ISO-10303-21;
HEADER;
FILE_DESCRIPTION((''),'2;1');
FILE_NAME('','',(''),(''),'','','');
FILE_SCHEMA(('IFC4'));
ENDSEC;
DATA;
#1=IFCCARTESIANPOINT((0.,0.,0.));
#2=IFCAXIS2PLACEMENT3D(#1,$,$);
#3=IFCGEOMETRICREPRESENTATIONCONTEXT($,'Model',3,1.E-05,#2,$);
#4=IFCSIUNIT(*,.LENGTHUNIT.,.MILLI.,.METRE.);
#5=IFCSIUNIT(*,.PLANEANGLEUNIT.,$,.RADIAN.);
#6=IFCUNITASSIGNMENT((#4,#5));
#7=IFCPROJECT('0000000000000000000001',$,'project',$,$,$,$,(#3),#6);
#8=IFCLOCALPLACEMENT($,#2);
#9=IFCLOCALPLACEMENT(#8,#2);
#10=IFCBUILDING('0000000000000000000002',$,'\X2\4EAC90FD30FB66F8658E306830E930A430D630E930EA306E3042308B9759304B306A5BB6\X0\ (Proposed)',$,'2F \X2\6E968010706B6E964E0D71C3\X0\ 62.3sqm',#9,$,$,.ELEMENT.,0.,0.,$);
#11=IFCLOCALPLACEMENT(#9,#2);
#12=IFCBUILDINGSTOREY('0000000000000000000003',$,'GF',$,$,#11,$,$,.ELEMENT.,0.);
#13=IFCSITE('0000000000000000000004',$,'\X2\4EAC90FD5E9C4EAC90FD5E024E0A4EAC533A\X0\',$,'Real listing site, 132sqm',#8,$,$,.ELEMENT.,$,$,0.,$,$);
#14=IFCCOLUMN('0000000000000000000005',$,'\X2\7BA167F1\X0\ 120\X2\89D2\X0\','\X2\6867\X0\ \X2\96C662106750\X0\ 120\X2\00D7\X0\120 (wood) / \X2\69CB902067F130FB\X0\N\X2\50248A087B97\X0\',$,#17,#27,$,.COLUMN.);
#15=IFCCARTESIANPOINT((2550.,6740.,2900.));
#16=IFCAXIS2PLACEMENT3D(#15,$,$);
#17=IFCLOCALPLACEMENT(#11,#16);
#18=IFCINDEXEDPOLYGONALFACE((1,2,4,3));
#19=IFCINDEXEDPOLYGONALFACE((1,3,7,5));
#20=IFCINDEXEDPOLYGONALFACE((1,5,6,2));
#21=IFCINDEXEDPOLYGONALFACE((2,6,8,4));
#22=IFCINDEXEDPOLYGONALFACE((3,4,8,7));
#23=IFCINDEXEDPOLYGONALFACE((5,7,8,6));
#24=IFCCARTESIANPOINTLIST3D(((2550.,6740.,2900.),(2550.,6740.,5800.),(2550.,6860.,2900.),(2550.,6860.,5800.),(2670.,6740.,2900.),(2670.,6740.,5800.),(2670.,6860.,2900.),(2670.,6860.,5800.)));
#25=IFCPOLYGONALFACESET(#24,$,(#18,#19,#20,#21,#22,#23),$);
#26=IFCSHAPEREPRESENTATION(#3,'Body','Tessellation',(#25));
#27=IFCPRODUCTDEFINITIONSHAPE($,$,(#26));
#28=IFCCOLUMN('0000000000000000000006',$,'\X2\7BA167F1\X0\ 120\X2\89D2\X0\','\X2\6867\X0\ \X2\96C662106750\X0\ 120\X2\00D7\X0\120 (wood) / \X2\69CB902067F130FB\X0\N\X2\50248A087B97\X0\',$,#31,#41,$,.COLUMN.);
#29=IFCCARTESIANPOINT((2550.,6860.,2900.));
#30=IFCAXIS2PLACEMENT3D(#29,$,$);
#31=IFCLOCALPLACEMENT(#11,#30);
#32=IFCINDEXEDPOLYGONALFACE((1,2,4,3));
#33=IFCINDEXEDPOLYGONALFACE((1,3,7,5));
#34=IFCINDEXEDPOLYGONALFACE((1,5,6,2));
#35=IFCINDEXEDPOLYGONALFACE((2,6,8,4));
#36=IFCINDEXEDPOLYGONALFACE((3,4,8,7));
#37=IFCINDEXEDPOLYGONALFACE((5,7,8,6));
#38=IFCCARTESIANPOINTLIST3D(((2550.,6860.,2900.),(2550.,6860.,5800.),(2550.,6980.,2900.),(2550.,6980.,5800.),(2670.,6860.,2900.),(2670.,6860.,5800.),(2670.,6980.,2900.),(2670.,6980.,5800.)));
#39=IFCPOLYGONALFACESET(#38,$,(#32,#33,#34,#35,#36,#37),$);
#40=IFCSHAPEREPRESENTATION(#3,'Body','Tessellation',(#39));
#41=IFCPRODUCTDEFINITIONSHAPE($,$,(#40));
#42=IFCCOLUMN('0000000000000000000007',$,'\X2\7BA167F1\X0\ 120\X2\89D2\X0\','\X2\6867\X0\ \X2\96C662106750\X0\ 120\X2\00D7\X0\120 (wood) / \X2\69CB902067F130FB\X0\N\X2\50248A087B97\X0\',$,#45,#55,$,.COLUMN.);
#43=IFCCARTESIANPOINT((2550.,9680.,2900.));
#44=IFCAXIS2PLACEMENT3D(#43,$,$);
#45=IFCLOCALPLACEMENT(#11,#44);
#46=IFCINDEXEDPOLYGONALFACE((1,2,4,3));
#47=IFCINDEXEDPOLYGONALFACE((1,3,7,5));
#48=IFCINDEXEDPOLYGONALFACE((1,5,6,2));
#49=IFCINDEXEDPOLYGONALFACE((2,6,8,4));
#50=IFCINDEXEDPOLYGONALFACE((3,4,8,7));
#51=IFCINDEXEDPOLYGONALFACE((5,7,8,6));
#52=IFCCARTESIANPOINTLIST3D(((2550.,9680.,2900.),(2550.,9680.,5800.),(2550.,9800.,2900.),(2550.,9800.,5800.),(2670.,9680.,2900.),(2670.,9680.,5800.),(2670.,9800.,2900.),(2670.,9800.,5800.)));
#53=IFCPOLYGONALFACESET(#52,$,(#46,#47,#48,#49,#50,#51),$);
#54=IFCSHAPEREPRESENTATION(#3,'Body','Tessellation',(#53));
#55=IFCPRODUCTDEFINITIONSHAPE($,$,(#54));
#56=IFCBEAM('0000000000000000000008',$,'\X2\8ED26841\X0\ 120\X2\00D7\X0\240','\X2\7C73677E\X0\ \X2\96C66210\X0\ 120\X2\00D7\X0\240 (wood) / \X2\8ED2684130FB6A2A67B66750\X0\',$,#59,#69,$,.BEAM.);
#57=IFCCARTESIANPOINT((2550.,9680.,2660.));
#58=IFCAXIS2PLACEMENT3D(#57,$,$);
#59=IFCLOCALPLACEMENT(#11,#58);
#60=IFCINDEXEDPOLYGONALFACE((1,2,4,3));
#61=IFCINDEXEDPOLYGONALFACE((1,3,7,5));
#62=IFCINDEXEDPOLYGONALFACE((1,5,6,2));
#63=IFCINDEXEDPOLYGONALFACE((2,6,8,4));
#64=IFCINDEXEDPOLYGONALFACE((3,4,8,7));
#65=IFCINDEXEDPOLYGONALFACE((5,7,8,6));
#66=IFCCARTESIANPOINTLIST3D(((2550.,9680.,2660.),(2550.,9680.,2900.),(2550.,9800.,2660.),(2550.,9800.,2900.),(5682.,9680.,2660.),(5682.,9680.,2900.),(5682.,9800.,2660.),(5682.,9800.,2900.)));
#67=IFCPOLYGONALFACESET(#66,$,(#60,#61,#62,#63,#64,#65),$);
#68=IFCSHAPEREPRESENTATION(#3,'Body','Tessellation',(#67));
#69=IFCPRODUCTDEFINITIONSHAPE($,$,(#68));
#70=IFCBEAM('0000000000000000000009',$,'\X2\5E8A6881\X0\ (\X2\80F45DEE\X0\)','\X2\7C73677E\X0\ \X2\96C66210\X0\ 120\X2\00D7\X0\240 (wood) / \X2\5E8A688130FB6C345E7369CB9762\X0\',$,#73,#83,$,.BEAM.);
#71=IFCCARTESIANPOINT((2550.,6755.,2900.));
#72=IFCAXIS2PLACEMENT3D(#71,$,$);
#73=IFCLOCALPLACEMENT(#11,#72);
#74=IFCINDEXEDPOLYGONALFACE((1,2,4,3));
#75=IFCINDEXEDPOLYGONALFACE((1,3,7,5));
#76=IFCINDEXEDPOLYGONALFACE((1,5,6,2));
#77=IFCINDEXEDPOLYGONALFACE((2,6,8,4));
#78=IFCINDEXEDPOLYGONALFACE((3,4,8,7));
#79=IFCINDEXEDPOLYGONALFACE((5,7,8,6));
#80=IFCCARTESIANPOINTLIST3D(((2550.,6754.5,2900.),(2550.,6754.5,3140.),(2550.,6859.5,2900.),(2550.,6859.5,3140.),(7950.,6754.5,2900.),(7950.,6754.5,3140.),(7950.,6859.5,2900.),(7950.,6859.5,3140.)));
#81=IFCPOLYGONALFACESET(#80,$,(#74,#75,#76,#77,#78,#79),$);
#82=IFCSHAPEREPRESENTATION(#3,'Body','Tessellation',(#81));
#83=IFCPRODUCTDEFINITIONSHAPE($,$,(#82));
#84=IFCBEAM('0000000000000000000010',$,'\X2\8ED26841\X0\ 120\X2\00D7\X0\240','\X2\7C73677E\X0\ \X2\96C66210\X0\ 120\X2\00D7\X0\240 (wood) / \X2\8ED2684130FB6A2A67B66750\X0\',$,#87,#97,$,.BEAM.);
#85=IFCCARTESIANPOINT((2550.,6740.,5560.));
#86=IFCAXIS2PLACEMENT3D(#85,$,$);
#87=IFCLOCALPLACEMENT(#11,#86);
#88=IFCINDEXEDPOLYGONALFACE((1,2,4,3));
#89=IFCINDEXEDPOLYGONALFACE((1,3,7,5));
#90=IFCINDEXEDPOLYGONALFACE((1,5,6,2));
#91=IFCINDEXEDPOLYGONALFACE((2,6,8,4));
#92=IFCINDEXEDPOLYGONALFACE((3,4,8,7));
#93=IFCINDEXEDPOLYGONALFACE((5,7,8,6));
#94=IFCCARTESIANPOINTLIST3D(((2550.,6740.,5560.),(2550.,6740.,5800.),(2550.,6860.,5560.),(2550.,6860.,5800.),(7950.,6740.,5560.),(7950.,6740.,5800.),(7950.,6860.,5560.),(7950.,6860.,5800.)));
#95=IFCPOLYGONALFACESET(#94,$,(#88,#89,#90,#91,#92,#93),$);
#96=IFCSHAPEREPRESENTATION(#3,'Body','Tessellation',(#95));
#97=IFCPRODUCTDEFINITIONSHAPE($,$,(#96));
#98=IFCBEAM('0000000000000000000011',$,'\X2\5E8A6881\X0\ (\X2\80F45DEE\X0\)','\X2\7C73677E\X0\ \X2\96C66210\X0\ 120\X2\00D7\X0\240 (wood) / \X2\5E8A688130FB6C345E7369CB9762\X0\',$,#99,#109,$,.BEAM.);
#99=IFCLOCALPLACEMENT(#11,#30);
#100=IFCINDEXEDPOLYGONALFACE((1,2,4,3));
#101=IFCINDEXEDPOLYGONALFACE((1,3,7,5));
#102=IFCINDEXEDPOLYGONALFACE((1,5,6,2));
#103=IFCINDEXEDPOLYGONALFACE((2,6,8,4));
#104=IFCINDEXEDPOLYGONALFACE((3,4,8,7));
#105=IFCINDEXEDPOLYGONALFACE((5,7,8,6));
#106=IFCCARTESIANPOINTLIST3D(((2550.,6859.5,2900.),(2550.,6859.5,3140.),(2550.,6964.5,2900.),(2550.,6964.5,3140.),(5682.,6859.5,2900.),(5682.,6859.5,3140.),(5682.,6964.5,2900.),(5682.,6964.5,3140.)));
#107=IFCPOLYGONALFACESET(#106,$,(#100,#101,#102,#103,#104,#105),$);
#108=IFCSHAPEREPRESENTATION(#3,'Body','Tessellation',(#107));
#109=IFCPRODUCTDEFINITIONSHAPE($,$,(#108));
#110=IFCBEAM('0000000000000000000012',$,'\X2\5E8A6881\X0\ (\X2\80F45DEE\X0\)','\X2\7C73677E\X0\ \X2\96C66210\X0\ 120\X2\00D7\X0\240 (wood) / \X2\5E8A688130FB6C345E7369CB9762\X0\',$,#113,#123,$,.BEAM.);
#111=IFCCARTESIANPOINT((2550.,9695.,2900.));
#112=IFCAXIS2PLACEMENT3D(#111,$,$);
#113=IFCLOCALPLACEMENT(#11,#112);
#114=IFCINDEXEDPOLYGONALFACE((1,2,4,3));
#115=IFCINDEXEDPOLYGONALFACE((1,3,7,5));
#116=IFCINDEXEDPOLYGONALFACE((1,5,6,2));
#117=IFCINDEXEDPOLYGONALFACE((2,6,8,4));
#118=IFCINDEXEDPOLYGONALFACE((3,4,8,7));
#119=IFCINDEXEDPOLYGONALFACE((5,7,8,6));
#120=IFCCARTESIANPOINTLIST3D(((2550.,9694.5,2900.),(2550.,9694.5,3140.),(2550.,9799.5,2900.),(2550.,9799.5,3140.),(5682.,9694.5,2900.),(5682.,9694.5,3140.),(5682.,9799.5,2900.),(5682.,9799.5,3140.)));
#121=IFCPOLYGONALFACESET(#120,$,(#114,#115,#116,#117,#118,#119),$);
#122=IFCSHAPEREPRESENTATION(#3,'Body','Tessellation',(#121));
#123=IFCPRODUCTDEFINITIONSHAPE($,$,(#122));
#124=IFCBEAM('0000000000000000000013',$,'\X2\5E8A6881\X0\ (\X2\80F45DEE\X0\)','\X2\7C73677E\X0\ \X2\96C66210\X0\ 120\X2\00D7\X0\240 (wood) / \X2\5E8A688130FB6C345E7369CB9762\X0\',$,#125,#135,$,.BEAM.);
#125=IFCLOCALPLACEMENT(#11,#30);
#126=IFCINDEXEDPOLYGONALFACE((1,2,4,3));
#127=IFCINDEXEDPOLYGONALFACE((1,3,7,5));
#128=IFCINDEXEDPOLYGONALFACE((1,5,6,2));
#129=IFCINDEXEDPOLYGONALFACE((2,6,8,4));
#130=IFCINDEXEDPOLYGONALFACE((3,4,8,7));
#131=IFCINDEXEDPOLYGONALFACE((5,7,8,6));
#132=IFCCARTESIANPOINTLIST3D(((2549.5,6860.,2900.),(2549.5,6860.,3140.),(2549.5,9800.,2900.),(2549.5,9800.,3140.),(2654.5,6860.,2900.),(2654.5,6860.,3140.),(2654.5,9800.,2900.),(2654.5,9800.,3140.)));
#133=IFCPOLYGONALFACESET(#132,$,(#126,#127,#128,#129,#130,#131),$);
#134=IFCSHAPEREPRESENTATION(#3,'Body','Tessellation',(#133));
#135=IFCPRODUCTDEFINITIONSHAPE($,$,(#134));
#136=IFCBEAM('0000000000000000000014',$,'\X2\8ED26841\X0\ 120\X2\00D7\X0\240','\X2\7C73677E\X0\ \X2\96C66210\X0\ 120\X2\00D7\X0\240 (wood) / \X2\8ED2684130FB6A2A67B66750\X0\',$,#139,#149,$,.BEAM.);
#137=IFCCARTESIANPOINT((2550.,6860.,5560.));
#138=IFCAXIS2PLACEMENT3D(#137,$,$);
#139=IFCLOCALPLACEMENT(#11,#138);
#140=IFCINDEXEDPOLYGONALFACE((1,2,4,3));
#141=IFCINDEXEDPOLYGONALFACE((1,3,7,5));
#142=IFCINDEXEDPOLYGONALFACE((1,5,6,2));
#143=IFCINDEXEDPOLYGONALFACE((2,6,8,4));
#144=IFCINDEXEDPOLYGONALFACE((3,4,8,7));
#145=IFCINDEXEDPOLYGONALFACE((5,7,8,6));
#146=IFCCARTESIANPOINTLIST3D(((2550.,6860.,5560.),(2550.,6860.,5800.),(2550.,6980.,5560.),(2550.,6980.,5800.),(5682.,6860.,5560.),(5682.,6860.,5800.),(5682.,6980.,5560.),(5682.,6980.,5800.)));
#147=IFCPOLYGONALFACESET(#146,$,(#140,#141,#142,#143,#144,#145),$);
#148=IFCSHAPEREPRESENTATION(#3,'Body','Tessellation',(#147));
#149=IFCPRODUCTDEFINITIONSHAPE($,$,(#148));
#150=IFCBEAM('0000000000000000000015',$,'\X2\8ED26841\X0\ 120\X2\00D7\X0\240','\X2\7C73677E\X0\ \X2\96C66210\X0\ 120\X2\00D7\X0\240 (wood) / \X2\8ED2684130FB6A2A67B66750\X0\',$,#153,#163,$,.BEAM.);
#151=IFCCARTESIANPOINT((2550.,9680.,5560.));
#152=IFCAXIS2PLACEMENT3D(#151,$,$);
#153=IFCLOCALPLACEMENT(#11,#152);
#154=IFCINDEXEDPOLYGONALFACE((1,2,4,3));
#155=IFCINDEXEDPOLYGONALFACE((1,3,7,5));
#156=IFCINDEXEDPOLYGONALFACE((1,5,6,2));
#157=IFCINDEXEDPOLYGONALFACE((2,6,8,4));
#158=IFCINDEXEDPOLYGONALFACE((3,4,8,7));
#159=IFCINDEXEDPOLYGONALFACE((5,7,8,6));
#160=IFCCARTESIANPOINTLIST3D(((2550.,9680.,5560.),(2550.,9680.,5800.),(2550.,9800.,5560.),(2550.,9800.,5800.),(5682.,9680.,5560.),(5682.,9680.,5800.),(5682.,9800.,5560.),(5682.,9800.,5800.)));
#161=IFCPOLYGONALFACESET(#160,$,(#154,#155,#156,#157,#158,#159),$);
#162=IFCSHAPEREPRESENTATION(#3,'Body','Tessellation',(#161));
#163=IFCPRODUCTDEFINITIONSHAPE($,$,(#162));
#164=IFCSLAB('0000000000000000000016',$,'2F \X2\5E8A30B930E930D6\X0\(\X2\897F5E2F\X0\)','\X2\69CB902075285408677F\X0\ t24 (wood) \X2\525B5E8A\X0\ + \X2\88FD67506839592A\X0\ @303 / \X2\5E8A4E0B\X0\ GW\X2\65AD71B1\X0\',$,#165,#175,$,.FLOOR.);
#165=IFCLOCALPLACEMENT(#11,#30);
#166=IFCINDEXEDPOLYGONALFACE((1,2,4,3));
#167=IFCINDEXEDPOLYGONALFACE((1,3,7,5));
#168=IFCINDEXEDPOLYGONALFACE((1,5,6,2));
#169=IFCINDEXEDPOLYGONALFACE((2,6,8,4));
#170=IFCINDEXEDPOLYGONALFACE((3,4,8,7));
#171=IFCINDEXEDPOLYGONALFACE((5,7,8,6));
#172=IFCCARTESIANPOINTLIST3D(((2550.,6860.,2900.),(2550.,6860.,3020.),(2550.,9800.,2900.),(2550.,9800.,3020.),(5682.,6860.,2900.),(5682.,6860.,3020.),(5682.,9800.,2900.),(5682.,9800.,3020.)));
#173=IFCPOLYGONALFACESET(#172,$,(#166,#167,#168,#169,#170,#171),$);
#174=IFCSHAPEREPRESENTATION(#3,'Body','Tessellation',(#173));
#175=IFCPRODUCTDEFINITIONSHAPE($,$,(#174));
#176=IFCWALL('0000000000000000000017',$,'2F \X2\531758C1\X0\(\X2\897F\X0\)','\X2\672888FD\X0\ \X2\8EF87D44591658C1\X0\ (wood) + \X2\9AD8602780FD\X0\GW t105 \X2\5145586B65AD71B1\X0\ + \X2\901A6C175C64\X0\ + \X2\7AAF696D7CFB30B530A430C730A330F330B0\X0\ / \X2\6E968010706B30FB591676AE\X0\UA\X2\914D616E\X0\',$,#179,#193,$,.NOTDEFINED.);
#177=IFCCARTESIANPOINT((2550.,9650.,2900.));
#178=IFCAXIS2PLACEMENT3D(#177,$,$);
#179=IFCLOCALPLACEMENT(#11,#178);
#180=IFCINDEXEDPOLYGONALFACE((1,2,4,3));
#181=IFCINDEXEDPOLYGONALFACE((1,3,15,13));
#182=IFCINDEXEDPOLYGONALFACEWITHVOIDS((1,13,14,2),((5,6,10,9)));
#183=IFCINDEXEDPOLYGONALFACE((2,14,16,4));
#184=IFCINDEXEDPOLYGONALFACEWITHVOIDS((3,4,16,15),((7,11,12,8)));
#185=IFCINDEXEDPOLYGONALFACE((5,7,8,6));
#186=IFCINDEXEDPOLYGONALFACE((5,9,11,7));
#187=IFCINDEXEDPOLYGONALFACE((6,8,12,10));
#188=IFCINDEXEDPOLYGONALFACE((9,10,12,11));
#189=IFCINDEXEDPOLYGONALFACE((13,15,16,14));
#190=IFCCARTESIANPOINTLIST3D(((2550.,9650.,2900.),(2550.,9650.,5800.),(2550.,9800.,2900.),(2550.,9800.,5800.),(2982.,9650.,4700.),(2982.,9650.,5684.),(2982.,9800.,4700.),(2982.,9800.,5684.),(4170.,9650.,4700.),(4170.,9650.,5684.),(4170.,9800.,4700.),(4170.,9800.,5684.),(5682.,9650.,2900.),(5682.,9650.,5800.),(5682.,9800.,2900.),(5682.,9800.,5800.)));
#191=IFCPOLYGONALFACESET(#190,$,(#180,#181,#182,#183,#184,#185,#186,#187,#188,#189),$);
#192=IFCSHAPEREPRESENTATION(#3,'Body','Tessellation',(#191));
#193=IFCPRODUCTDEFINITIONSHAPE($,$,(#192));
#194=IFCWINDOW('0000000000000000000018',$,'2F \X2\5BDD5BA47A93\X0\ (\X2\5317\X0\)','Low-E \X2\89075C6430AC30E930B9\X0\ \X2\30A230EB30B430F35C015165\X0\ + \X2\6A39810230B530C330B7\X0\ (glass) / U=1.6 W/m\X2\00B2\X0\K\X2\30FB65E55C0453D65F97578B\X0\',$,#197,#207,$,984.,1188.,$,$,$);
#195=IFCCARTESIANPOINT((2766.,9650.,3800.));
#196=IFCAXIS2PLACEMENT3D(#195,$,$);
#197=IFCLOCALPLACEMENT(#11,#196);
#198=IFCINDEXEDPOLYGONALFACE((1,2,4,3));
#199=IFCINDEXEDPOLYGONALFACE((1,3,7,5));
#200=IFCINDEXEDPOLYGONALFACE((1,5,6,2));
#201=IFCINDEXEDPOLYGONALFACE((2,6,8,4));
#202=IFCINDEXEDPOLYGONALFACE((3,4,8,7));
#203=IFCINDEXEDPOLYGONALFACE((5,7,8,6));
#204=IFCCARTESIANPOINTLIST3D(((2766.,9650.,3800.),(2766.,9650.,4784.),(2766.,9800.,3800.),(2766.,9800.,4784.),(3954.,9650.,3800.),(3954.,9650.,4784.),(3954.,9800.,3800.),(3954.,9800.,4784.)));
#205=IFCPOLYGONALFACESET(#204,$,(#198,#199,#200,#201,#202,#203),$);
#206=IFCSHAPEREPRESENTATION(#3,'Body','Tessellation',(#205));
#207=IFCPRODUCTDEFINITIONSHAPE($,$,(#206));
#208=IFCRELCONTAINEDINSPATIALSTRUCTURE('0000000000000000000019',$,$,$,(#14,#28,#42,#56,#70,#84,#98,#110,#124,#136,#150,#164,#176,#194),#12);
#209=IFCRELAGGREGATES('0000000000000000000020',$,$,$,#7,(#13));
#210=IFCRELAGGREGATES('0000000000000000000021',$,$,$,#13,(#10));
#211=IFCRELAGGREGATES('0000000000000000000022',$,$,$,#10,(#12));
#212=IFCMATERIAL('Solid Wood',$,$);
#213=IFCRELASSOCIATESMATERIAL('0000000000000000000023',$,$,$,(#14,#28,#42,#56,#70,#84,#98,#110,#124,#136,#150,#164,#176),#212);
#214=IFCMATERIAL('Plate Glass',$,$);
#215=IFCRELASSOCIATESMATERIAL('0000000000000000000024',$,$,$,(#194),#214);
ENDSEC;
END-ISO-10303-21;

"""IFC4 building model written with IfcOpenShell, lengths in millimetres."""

from ifc_helpers import new_model, si_unit, frame, frame_2d, origin, place, context, project, spatial, rectangle, extrude, material, element, fill, save


model = new_model("IFC4")

# Units and contexts
model_context = context("Model", 3, precision=1e-05, world=origin())
ifc_project = project(units=[si_unit("LENGTHUNIT", "METRE", prefix="MILLI"), si_unit("PLANEANGLEUNIT", "RADIAN")], contexts=[model_context])

# Site, building, storey
site_placement = place(None, origin())
site = spatial("IfcSite", under=ifc_project, at=site_placement, Name="京都府京都市上京区", ObjectType="Real listing site, 132sqm", CompositionType="ELEMENT", RefElevation=0.0)
building_placement = place(site_placement, origin())
building = spatial("IfcBuilding", under=site, at=building_placement, Name="京都・書斎とライブラリのある静かな家 (Proposed)", ObjectType="2F 準耐火準不燃 62.3sqm", CompositionType="ELEMENT", ElevationOfRefHeight=0.0, ElevationOfTerrain=0.0)
storey_placement = place(building_placement, origin())
storey = spatial("IfcBuildingStorey", under=building, at=storey_placement, Name="GF", CompositionType="ELEMENT", Elevation=0.0)

# Columns
ifc_material_1 = material(Name="Solid Wood")
column_1_placement = place(storey_placement, frame((2550.0, 6740.0, 2900.0)))
element("IfcColumn", 1, at=column_1_placement, inside=storey, material=ifc_material_1, Name="管柱 120角", Description="桧 集成材 120×120 (wood) / 構造柱・N値計算", PredefinedType="COLUMN", context=model_context, shape_type="SweptSolid", body=[
    extrude(rectangle(XDim=120.0, YDim=120.0, at=frame_2d((60.0, 60.0))), frame((2550.0, 6740.0, 2900.0)), (0.0, 0.0, 1.0), 2900.0),
])
column_2_placement = place(storey_placement, frame((2550.0, 6860.0, 2900.0)))
element("IfcColumn", 2, at=column_2_placement, inside=storey, material=ifc_material_1, Name="管柱 120角", Description="桧 集成材 120×120 (wood) / 構造柱・N値計算", PredefinedType="COLUMN", context=model_context, shape_type="SweptSolid", body=[
    extrude(rectangle(XDim=120.0, YDim=120.0, at=frame_2d((60.0, 60.0))), frame((2550.0, 6860.0, 2900.0)), (0.0, 0.0, 1.0), 2900.0),
])
column_3_placement = place(storey_placement, frame((2550.0, 9680.0, 2900.0)))
element("IfcColumn", 3, at=column_3_placement, inside=storey, material=ifc_material_1, Name="管柱 120角", Description="桧 集成材 120×120 (wood) / 構造柱・N値計算", PredefinedType="COLUMN", context=model_context, shape_type="SweptSolid", body=[
    extrude(rectangle(XDim=120.0, YDim=120.0, at=frame_2d((60.0, 60.0))), frame((2550.0, 9680.0, 2900.0)), (0.0, 0.0, 1.0), 2900.0),
])

# Beams
beam_1_placement = place(storey_placement, frame((2550.0, 9680.0, 2660.0)))
element("IfcBeam", 4, at=beam_1_placement, inside=storey, material=ifc_material_1, Name="軒桁 120×240", Description="米松 集成 120×240 (wood) / 軒桁・横架材", PredefinedType="BEAM", context=model_context, shape_type="SweptSolid", body=[
    extrude(rectangle(XDim=3132.0, YDim=120.0, at=frame_2d((1566.0, 60.0))), frame((2550.0, 9680.0, 2660.0)), (0.0, 0.0, 1.0), 240.0),
])
beam_2_placement = place(storey_placement, frame((2550.0, 6755.0, 2900.0)))
element("IfcBeam", 5, at=beam_2_placement, inside=storey, material=ifc_material_1, Name="床梁 (胴差)", Description="米松 集成 120×240 (wood) / 床梁・水平構面", PredefinedType="BEAM", context=model_context, shape_type="SweptSolid", body=[
    extrude(rectangle(XDim=5400.0, YDim=105.0, at=frame_2d((2700.0, 52.0))), frame((2550.0, 6755.0, 2900.0)), (0.0, 0.0, 1.0), 240.0),
])
beam_3_placement = place(storey_placement, frame((2550.0, 6740.0, 5560.0)))
element("IfcBeam", 6, at=beam_3_placement, inside=storey, material=ifc_material_1, Name="軒桁 120×240", Description="米松 集成 120×240 (wood) / 軒桁・横架材", PredefinedType="BEAM", context=model_context, shape_type="SweptSolid", body=[
    extrude(rectangle(XDim=5400.0, YDim=120.0, at=frame_2d((2700.0, 60.0))), frame((2550.0, 6740.0, 5560.0)), (0.0, 0.0, 1.0), 240.0),
])
beam_4_placement = place(storey_placement, frame((2550.0, 6860.0, 2900.0)))
element("IfcBeam", 7, at=beam_4_placement, inside=storey, material=ifc_material_1, Name="床梁 (胴差)", Description="米松 集成 120×240 (wood) / 床梁・水平構面", PredefinedType="BEAM", context=model_context, shape_type="SweptSolid", body=[
    extrude(rectangle(XDim=3132.0, YDim=105.0, at=frame_2d((1566.0, 52.0))), frame((2550.0, 6860.0, 2900.0)), (0.0, 0.0, 1.0), 240.0),
])
beam_5_placement = place(storey_placement, frame((2550.0, 9695.0, 2900.0)))
element("IfcBeam", 8, at=beam_5_placement, inside=storey, material=ifc_material_1, Name="床梁 (胴差)", Description="米松 集成 120×240 (wood) / 床梁・水平構面", PredefinedType="BEAM", context=model_context, shape_type="SweptSolid", body=[
    extrude(rectangle(XDim=3132.0, YDim=105.0, at=frame_2d((1566.0, 52.0))), frame((2550.0, 9695.0, 2900.0)), (0.0, 0.0, 1.0), 240.0),
])
beam_6_placement = place(storey_placement, frame((2550.0, 6860.0, 2900.0)))
element("IfcBeam", 9, at=beam_6_placement, inside=storey, material=ifc_material_1, Name="床梁 (胴差)", Description="米松 集成 120×240 (wood) / 床梁・水平構面", PredefinedType="BEAM", context=model_context, shape_type="SweptSolid", body=[
    extrude(rectangle(XDim=105.0, YDim=2940.0, at=frame_2d((52.0, 1470.0))), frame((2550.0, 6860.0, 2900.0)), (0.0, 0.0, 1.0), 240.0),
])
beam_7_placement = place(storey_placement, frame((2550.0, 6860.0, 5560.0)))
element("IfcBeam", 10, at=beam_7_placement, inside=storey, material=ifc_material_1, Name="軒桁 120×240", Description="米松 集成 120×240 (wood) / 軒桁・横架材", PredefinedType="BEAM", context=model_context, shape_type="SweptSolid", body=[
    extrude(rectangle(XDim=3132.0, YDim=120.0, at=frame_2d((1566.0, 60.0))), frame((2550.0, 6860.0, 5560.0)), (0.0, 0.0, 1.0), 240.0),
])
beam_8_placement = place(storey_placement, frame((2550.0, 9680.0, 5560.0)))
element("IfcBeam", 11, at=beam_8_placement, inside=storey, material=ifc_material_1, Name="軒桁 120×240", Description="米松 集成 120×240 (wood) / 軒桁・横架材", PredefinedType="BEAM", context=model_context, shape_type="SweptSolid", body=[
    extrude(rectangle(XDim=3132.0, YDim=120.0, at=frame_2d((1566.0, 60.0))), frame((2550.0, 9680.0, 5560.0)), (0.0, 0.0, 1.0), 240.0),
])

# Slab
slab_placement = place(storey_placement, frame((2550.0, 6860.0, 2900.0)))
element("IfcSlab", 12, at=slab_placement, inside=storey, material=ifc_material_1, Name="2F 床スラブ(西帯)", Description="構造用合板 t24 (wood) 剛床 + 製材根太 @303 / 床下 GW断熱", PredefinedType="FLOOR", context=model_context, shape_type="SweptSolid", body=[
    extrude(rectangle(XDim=3132.0, YDim=2940.0, at=frame_2d((1566.0, 1470.0))), frame((2550.0, 6860.0, 2900.0)), (0.0, 0.0, 1.0), 120.0),
])

# Wall, opening, window
wall_1_placement = place(storey_placement, frame((2550.0, 9650.0, 2900.0)))
wall_1 = element("IfcWall", 13, at=wall_1_placement, inside=storey, material=ifc_material_1, Name="2F 北壁(西)", Description="木製 軸組外壁 (wood) + 高性能GW t105 充填断熱 + 通気層 + 窯業系サイディング / 準耐火・外皮UA配慮", PredefinedType="NOTDEFINED", context=model_context, shape_type="SweptSolid", body=[
    extrude(rectangle(XDim=3132.0, YDim=150.0, at=frame_2d((1566.0, 75.0))), frame((2550.0, 9650.0, 2900.0)), (0.0, 0.0, 1.0), 2900.0),
])
opening_placement = place(storey_placement, frame((2766.0, 9650.0, 3800.0)))
opening = element("IfcOpeningElement", 14, at=opening_placement, cuts=wall_1, PredefinedType="NOTDEFINED", context=model_context, shape_type="SweptSolid", body=[
    extrude(rectangle(XDim=1188.0, YDim=150.0, at=frame_2d((594.0, 75.0))), frame((2766.0, 9650.0, 3800.0)), (0.0, 0.0, 1.0), 984.0),
])
ifc_material_2 = material(Name="Plate Glass")
window_placement = place(storey_placement, frame((2766.0, 9650.0, 3800.0)))
window = element("IfcWindow", 15, at=window_placement, inside=storey, material=ifc_material_2, Name="2F 寝室窓 (北)", Description="Low-E 複層ガラス アルゴン封入 + 樹脂サッシ (glass) / U=1.6 W/m²K・日射取得型", OverallHeight=984.0, OverallWidth=1188.0, context=model_context, shape_type="SweptSolid", body=[
    extrude(rectangle(XDim=1188.0, YDim=150.0, at=frame_2d((594.0, 75.0))), frame((2766.0, 9650.0, 3800.0)), (0.0, 0.0, 1.0), 984.0),
])
fill(opening, window)

save(model, "model.ifc")
